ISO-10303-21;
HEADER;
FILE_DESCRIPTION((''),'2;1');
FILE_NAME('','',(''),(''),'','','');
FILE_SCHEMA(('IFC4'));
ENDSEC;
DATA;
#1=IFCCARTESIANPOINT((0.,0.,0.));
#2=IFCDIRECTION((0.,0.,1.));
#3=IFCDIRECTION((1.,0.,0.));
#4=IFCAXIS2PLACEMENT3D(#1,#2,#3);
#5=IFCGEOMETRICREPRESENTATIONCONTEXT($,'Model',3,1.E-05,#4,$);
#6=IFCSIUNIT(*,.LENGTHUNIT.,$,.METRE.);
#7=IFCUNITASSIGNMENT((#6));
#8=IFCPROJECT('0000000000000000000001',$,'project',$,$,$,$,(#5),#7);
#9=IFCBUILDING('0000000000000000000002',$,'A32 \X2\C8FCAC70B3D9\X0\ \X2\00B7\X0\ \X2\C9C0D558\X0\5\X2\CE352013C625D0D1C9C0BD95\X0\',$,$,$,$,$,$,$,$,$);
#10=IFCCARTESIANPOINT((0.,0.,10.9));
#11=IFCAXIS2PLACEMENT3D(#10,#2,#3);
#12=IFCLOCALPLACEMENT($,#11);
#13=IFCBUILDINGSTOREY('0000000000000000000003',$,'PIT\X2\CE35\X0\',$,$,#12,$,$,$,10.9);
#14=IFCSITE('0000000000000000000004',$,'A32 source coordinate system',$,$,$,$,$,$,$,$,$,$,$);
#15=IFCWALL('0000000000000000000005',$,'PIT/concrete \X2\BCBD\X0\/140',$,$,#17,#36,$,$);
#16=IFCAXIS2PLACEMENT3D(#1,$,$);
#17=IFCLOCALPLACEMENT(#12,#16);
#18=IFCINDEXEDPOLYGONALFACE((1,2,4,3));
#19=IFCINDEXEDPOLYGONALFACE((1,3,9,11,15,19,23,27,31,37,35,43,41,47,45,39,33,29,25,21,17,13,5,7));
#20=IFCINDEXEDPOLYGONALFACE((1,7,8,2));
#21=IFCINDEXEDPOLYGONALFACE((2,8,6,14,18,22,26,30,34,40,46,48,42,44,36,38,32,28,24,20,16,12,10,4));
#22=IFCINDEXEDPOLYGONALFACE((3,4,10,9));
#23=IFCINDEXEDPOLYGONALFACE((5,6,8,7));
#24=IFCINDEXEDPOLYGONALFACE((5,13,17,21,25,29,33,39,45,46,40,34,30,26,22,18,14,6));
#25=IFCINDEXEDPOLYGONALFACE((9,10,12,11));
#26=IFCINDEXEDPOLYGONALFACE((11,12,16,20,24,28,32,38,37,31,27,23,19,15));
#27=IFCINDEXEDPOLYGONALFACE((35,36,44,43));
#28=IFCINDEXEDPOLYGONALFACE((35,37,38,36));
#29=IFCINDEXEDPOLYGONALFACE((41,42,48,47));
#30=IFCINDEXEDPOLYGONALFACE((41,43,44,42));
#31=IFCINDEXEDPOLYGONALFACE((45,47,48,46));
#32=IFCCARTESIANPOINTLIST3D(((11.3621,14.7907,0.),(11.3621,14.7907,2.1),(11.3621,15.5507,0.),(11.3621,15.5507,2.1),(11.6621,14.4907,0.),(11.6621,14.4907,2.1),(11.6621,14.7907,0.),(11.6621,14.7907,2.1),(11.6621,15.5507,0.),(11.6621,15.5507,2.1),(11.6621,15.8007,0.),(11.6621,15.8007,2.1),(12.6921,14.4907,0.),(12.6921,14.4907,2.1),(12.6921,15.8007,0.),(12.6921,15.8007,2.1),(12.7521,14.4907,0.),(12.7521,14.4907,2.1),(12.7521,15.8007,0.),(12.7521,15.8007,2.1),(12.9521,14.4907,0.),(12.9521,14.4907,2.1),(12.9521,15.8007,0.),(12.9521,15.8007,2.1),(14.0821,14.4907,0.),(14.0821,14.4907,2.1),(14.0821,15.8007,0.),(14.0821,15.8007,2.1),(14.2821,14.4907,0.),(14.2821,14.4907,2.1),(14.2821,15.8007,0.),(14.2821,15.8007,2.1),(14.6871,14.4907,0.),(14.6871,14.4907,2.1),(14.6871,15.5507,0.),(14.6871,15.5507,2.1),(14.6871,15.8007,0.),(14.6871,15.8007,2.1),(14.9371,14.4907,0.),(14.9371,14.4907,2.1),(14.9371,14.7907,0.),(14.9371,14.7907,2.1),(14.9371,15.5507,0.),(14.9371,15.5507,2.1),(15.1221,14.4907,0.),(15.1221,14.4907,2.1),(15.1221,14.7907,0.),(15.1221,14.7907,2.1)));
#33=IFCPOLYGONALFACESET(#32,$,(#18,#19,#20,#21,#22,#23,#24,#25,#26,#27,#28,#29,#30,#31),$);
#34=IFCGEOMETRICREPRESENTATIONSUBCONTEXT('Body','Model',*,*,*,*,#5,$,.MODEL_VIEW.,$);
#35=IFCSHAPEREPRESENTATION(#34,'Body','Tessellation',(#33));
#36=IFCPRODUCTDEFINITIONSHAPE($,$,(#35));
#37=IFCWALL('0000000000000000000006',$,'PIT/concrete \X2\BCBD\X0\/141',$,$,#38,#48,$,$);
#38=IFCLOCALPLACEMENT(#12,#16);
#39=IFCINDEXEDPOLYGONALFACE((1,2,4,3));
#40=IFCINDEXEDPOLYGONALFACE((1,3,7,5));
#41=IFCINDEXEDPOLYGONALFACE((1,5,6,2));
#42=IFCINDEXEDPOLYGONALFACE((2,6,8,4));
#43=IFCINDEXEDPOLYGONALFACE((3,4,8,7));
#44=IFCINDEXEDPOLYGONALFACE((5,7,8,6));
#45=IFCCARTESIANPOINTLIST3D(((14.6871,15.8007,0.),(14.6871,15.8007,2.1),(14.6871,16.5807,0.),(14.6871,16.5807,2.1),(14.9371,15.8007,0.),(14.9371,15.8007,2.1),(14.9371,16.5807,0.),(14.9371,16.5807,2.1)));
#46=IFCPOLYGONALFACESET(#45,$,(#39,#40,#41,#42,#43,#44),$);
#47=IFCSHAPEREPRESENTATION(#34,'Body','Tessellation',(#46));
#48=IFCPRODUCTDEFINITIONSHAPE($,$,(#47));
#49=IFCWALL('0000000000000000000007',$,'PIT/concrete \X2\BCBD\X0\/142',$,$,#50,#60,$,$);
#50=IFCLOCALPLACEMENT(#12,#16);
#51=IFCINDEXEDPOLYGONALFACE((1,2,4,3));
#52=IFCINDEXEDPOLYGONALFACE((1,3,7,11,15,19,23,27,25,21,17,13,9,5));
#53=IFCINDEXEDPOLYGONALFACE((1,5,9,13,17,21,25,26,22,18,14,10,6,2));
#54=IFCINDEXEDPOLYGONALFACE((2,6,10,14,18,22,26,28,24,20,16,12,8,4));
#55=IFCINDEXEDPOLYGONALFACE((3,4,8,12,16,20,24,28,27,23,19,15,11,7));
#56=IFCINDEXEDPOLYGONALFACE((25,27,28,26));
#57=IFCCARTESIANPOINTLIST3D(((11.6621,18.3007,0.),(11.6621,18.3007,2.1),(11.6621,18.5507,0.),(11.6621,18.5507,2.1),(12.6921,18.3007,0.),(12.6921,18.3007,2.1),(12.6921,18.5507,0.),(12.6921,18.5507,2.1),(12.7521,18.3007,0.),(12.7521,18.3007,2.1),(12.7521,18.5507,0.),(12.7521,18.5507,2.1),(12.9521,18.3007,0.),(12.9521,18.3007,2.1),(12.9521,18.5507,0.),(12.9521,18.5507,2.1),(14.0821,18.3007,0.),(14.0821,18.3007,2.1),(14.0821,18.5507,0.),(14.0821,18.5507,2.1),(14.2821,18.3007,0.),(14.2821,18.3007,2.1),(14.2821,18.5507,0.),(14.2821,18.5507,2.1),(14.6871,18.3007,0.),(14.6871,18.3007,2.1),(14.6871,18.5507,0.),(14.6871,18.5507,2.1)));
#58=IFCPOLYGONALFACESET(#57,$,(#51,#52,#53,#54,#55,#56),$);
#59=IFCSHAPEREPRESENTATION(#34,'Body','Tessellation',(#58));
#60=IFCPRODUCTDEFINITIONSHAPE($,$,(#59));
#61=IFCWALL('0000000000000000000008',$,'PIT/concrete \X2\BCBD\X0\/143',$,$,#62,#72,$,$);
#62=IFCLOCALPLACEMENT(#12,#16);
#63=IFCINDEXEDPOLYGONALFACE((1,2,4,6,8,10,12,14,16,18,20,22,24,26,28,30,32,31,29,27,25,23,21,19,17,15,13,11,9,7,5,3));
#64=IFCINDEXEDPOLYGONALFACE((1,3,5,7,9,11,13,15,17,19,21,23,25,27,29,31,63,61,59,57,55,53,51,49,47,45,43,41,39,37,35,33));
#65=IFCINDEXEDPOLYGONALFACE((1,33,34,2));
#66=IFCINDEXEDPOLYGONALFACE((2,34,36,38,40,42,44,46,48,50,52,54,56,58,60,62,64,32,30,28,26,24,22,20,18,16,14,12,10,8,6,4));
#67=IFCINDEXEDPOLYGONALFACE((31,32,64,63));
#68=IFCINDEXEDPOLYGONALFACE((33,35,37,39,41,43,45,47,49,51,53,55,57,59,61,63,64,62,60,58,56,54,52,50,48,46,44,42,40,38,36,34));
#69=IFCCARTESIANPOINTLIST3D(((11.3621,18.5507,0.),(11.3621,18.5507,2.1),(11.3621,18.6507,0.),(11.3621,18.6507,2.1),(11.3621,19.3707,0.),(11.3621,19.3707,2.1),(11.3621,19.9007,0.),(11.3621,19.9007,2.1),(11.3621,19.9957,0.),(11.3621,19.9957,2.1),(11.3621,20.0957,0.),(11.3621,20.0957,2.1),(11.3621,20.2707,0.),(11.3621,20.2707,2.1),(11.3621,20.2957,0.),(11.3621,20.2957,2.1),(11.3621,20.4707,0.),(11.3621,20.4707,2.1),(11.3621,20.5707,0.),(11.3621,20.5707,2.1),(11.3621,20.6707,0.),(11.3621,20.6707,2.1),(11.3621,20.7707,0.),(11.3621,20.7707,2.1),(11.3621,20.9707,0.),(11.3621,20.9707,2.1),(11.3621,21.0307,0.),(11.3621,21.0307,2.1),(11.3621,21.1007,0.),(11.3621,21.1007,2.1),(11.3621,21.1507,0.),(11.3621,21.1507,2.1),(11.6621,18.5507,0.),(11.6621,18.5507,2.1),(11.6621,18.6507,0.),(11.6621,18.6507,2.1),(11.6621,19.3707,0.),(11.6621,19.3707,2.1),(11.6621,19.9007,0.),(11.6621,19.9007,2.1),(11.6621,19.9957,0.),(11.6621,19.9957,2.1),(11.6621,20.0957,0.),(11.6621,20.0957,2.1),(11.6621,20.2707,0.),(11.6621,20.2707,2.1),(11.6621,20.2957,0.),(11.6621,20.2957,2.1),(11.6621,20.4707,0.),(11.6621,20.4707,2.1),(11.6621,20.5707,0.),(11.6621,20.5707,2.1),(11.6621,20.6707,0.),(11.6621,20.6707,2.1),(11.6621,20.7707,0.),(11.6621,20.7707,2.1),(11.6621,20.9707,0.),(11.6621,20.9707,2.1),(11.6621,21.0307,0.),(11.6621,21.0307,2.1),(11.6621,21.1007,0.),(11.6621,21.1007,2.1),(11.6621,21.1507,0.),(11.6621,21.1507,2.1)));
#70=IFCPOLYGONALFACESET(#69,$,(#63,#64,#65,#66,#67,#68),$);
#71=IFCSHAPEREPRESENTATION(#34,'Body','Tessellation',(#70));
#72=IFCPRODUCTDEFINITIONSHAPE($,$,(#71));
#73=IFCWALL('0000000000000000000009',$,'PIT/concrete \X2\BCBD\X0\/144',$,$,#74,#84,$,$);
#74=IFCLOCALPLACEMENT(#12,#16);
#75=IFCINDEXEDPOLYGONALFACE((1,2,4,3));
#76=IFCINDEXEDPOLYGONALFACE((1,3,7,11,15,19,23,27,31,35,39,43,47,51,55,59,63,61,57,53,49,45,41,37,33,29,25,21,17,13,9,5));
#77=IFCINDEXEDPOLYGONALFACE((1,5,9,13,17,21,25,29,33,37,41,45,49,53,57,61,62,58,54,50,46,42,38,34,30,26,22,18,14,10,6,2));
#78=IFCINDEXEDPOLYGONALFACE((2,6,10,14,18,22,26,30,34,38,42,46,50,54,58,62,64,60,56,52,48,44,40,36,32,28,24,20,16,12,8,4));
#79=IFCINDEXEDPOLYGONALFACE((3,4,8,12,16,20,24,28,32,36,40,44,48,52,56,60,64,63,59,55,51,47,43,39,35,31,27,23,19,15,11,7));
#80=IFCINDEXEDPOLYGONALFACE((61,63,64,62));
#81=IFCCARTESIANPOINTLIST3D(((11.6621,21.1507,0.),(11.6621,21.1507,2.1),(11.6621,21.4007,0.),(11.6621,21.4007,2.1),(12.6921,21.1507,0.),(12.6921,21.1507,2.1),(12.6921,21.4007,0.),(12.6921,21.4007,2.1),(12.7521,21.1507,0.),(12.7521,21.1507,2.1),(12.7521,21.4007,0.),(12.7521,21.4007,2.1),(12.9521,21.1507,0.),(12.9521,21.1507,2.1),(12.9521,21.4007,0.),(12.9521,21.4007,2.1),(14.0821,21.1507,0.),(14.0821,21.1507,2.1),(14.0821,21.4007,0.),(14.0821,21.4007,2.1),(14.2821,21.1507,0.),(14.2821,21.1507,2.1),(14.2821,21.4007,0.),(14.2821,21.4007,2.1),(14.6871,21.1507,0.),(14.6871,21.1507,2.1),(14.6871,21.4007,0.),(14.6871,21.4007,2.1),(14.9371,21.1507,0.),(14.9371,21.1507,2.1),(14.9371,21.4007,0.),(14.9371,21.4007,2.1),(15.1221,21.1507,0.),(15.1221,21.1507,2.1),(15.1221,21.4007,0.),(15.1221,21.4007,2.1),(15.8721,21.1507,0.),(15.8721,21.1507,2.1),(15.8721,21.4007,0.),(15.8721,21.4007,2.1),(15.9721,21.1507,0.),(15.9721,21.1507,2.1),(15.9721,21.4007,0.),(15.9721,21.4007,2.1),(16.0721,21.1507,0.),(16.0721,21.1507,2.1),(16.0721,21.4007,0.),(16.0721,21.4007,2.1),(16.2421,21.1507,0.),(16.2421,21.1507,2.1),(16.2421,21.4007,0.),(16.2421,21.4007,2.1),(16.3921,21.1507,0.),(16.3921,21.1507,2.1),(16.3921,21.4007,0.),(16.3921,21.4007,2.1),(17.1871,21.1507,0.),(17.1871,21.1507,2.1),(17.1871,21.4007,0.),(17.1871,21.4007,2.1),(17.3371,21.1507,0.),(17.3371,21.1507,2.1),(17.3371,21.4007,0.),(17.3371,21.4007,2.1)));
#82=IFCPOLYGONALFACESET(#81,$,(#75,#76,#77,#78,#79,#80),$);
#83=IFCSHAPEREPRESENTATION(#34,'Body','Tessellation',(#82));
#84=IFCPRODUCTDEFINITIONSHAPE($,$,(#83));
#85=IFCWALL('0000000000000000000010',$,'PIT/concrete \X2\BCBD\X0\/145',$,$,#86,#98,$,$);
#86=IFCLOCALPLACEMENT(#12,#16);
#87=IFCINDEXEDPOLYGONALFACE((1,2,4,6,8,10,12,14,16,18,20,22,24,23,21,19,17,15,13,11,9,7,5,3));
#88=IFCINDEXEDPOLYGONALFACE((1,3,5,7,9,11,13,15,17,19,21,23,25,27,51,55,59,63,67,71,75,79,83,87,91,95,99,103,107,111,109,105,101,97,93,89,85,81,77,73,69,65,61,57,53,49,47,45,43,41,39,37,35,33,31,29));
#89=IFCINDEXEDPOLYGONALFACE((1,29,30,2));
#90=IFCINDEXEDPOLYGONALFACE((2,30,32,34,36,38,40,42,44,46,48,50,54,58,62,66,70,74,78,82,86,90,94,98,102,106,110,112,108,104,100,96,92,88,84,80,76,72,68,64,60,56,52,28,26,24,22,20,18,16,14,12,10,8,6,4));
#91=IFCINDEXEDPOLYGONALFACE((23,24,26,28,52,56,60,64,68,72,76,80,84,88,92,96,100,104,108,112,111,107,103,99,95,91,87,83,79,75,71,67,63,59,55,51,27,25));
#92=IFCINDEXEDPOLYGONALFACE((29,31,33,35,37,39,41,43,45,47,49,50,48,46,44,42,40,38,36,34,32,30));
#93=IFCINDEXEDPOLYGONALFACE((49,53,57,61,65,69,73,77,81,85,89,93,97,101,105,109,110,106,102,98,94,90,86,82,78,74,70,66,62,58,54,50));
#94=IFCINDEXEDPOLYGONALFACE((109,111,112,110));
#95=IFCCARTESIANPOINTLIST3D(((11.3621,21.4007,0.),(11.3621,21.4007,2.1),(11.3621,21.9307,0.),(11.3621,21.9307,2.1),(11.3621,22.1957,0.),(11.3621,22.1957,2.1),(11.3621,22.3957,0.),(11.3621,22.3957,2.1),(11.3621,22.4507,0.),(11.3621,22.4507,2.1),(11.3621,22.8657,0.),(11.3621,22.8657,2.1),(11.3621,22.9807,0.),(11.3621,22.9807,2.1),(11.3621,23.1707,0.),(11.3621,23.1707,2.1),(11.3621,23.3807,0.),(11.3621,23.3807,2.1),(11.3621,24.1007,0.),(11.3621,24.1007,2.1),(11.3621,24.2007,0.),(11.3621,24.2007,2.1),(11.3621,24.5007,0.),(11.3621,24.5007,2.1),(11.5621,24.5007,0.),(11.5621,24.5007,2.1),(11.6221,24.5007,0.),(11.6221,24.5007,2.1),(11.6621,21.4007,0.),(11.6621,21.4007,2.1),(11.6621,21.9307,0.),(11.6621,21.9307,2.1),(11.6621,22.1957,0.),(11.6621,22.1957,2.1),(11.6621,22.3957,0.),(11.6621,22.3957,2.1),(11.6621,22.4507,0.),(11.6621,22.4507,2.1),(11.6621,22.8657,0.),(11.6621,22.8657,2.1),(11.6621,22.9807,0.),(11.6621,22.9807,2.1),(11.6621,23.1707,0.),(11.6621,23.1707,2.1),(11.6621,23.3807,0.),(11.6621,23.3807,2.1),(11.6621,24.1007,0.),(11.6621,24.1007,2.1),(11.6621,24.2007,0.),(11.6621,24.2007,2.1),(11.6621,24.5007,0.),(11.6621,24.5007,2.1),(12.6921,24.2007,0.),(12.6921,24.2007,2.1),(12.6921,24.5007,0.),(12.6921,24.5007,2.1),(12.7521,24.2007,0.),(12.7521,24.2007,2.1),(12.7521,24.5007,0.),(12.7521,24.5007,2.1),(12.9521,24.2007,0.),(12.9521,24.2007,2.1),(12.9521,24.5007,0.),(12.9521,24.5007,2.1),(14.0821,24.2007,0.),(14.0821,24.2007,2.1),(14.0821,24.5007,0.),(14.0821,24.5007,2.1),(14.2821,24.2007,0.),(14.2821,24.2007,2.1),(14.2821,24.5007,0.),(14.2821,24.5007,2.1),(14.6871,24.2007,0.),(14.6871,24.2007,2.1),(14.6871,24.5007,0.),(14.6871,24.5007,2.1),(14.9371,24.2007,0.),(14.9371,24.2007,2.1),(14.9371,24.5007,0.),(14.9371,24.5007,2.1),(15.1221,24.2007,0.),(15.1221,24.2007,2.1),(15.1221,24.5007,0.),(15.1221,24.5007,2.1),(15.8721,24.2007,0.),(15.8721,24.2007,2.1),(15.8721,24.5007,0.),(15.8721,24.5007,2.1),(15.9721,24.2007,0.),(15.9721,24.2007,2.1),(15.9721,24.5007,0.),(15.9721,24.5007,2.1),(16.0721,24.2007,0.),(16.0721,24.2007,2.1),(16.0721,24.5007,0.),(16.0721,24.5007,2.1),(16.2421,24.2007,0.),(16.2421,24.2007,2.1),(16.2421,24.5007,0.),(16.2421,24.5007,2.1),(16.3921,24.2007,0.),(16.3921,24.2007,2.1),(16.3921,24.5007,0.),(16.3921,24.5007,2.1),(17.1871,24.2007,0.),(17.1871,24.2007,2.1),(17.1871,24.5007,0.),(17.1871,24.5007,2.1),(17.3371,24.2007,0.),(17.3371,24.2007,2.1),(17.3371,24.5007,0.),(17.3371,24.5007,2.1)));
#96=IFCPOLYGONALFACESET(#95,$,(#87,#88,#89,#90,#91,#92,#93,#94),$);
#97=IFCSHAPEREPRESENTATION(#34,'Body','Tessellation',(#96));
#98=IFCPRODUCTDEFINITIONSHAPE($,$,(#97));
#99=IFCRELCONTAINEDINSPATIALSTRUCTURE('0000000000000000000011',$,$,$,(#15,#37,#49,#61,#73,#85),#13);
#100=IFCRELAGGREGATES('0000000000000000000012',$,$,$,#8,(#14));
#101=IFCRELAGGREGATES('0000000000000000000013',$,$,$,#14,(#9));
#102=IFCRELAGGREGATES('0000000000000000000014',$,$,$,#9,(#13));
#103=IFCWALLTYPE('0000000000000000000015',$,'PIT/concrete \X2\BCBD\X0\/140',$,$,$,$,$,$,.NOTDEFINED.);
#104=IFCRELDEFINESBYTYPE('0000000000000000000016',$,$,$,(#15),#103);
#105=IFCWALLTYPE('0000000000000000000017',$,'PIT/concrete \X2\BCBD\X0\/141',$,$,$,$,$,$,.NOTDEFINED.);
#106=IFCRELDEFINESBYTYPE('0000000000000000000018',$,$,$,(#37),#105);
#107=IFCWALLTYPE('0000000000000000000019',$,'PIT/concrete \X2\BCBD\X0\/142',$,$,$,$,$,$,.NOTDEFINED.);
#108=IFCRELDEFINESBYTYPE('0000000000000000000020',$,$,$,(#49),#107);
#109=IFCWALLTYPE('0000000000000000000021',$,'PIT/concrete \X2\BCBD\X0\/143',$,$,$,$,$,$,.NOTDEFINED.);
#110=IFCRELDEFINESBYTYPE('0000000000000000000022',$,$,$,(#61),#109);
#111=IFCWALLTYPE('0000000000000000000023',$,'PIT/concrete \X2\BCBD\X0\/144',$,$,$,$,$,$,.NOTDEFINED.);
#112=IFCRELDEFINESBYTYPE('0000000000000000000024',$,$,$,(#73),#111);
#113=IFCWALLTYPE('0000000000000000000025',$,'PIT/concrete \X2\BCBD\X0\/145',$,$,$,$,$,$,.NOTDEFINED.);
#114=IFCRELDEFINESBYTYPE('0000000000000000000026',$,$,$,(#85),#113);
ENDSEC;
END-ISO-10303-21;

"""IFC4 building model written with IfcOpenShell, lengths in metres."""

from ifc_helpers import new_model, si_unit, frame, origin, origin_with_axes, place, context, subcontext, project, spatial, polyline, outline, extrude, source, transform, mapped, type_object, type_shapes, element, save


model = new_model("IFC4")

# Units and contexts
model_context = context("Model", 3, precision=1e-05, world=origin_with_axes())
body_context = subcontext(model_context, "Body", "Model", "MODEL_VIEW")
ifc_project = project(units=[si_unit("LENGTHUNIT", "METRE")], contexts=[model_context])

# Site, building, storey
site = spatial("IfcSite", under=ifc_project, Name="A32 source coordinate system")
building = spatial("IfcBuilding", under=site, Name="A32 주거동 · 지하5층–옥탑지붕")
storey_placement = place(None, frame((0.0, 0.0, 10.9), z_axis=(0.0, 0.0, 1.0), x_axis=(1.0, 0.0, 0.0)))
storey = spatial("IfcBuildingStorey", under=building, at=storey_placement, Name="PIT층", Elevation=10.9)

# Walls
wall_type_1 = type_object("IfcWallType", Name="PIT/concrete 벽/140", PredefinedType="NOTDEFINED")
shared_shape_1 = source(origin(), body_context, "Body", "SweptSolid", [
    extrude(outline(polyline([(12.9521, 15.8007), (14.0821, 15.8007), (14.2821, 15.8007), (14.6871, 15.8007), (14.6871, 15.5507), (14.9371, 15.5507), (14.9371, 14.7907), (15.1221, 14.7907), (15.1221, 14.4907), (14.9371, 14.4907), (14.6871, 14.4907), (14.2821, 14.4907), (14.0821, 14.4907), (12.9521, 14.4907), (12.7521, 14.4907), (12.6921, 14.4907), (11.6621, 14.4907), (11.6621, 14.7907), (11.3621, 14.7907), (11.3621, 15.5507), (11.6621, 15.5507), (11.6621, 15.8007), (12.6921, 15.8007), (12.7521, 15.8007), (12.9521, 15.8007)])), origin(), (0.0, 0.0, 1.0), 2.1),
])
type_shapes(wall_type_1, [shared_shape_1])
wall_1_placement = place(storey_placement, origin_with_axes())
element("IfcWall", 1, at=wall_1_placement, inside=storey, type_object=wall_type_1, Name="PIT/concrete 벽/140", context=body_context, shape_type="MappedRepresentation", body=[
    mapped(shared_shape_1, transform((0.0, 0.0, 0.0), scale=1.0)),
])
wall_type_2 = type_object("IfcWallType", Name="PIT/concrete 벽/141", PredefinedType="NOTDEFINED")
shared_shape_2 = source(origin(), body_context, "Body", "SweptSolid", [
    extrude(outline(polyline([(14.9371, 15.8007), (14.6871, 15.8007), (14.6871, 16.5807), (14.9371, 16.5807), (14.9371, 15.8007)])), origin(), (0.0, 0.0, 1.0), 2.1),
])
type_shapes(wall_type_2, [shared_shape_2])
wall_2_placement = place(storey_placement, origin_with_axes())
element("IfcWall", 2, at=wall_2_placement, inside=storey, type_object=wall_type_2, Name="PIT/concrete 벽/141", context=body_context, shape_type="MappedRepresentation", body=[
    mapped(shared_shape_2, transform((0.0, 0.0, 0.0), scale=1.0)),
])
wall_type_3 = type_object("IfcWallType", Name="PIT/concrete 벽/142", PredefinedType="NOTDEFINED")
shared_shape_3 = source(origin(), body_context, "Body", "SweptSolid", [
    extrude(outline(polyline([(12.7521, 18.5507), (12.9521, 18.5507), (14.0821, 18.5507), (14.2821, 18.5507), (14.6871, 18.5507), (14.6871, 18.3007), (14.2821, 18.3007), (14.0821, 18.3007), (12.9521, 18.3007), (12.7521, 18.3007), (12.6921, 18.3007), (11.6621, 18.3007), (11.6621, 18.5507), (12.6921, 18.5507), (12.7521, 18.5507)])), origin(), (0.0, 0.0, 1.0), 2.1),
])
type_shapes(wall_type_3, [shared_shape_3])
wall_3_placement = place(storey_placement, origin_with_axes())
element("IfcWall", 3, at=wall_3_placement, inside=storey, type_object=wall_type_3, Name="PIT/concrete 벽/142", context=body_context, shape_type="MappedRepresentation", body=[
    mapped(shared_shape_3, transform((0.0, 0.0, 0.0), scale=1.0)),
])
wall_type_4 = type_object("IfcWallType", Name="PIT/concrete 벽/143", PredefinedType="NOTDEFINED")
shared_shape_4 = source(origin(), body_context, "Body", "SweptSolid", [
    extrude(outline(polyline([(11.3621, 19.3707), (11.3621, 19.9007), (11.3621, 19.9957), (11.3621, 20.0957), (11.3621, 20.2707), (11.3621, 20.2957), (11.3621, 20.4707), (11.3621, 20.5707), (11.3621, 20.6707), (11.3621, 20.7707), (11.3621, 20.9707), (11.3621, 21.0307), (11.3621, 21.1007), (11.3621, 21.1507), (11.6621, 21.1507), (11.6621, 21.1007), (11.6621, 21.0307), (11.6621, 20.9707), (11.6621, 20.7707), (11.6621, 20.6707), (11.6621, 20.5707), (11.6621, 20.4707), (11.6621, 20.2957), (11.6621, 20.2707), (11.6621, 20.0957), (11.6621, 19.9957), (11.6621, 19.9007), (11.6621, 19.3707), (11.6621, 18.6507), (11.6621, 18.5507), (11.3621, 18.5507), (11.3621, 18.6507), (11.3621, 19.3707)])), origin(), (0.0, 0.0, 1.0), 2.1),
])
type_shapes(wall_type_4, [shared_shape_4])
wall_4_placement = place(storey_placement, origin_with_axes())
element("IfcWall", 4, at=wall_4_placement, inside=storey, type_object=wall_type_4, Name="PIT/concrete 벽/143", context=body_context, shape_type="MappedRepresentation", body=[
    mapped(shared_shape_4, transform((0.0, 0.0, 0.0), scale=1.0)),
])
wall_type_5 = type_object("IfcWallType", Name="PIT/concrete 벽/144", PredefinedType="NOTDEFINED")
shared_shape_5 = source(origin(), body_context, "Body", "SweptSolid", [
    extrude(outline(polyline([(12.7521, 21.4007), (12.9521, 21.4007), (14.0821, 21.4007), (14.2821, 21.4007), (14.6871, 21.4007), (14.9371, 21.4007), (15.1221, 21.4007), (15.8721, 21.4007), (15.9721, 21.4007), (16.0721, 21.4007), (16.2421, 21.4007), (16.3921, 21.4007), (17.1871, 21.4007), (17.3371, 21.4007), (17.3371, 21.1507), (17.1871, 21.1507), (16.3921, 21.1507), (16.2421, 21.1507), (16.0721, 21.1507), (15.9721, 21.1507), (15.8721, 21.1507), (15.1221, 21.1507), (14.9371, 21.1507), (14.6871, 21.1507), (14.2821, 21.1507), (14.0821, 21.1507), (12.9521, 21.1507), (12.7521, 21.1507), (12.6921, 21.1507), (11.6621, 21.1507), (11.6621, 21.4007), (12.6921, 21.4007), (12.7521, 21.4007)])), origin(), (0.0, 0.0, 1.0), 2.1),
])
type_shapes(wall_type_5, [shared_shape_5])
wall_5_placement = place(storey_placement, origin_with_axes())
element("IfcWall", 5, at=wall_5_placement, inside=storey, type_object=wall_type_5, Name="PIT/concrete 벽/144", context=body_context, shape_type="MappedRepresentation", body=[
    mapped(shared_shape_5, transform((0.0, 0.0, 0.0), scale=1.0)),
])
wall_type_6 = type_object("IfcWallType", Name="PIT/concrete 벽/145", PredefinedType="NOTDEFINED")
shared_shape_6 = source(origin(), body_context, "Body", "SweptSolid", [
    extrude(outline(polyline([(11.3621, 22.1957), (11.3621, 22.3957), (11.3621, 22.4507), (11.3621, 22.8657), (11.3621, 22.9807), (11.3621, 23.1707), (11.3621, 23.3807), (11.3621, 24.1007), (11.3621, 24.2007), (11.3621, 24.5007), (11.5621, 24.5007), (11.6221, 24.5007), (11.6621, 24.5007), (12.6921, 24.5007), (12.7521, 24.5007), (12.9521, 24.5007), (14.0821, 24.5007), (14.2821, 24.5007), (14.6871, 24.5007), (14.9371, 24.5007), (15.1221, 24.5007), (15.8721, 24.5007), (15.9721, 24.5007), (16.0721, 24.5007), (16.2421, 24.5007), (16.3921, 24.5007), (17.1871, 24.5007), (17.3371, 24.5007), (17.3371, 24.2007), (17.1871, 24.2007), (16.3921, 24.2007), (16.2421, 24.2007), (16.0721, 24.2007), (15.9721, 24.2007), (15.8721, 24.2007), (15.1221, 24.2007), (14.9371, 24.2007), (14.6871, 24.2007), (14.2821, 24.2007), (14.0821, 24.2007), (12.9521, 24.2007), (12.7521, 24.2007), (12.6921, 24.2007), (11.6621, 24.2007), (11.6621, 24.1007), (11.6621, 23.3807), (11.6621, 23.1707), (11.6621, 22.9807), (11.6621, 22.8657), (11.6621, 22.4507), (11.6621, 22.3957), (11.6621, 22.1957), (11.6621, 21.9307), (11.6621, 21.4007), (11.3621, 21.4007), (11.3621, 21.9307), (11.3621, 22.1957)])), origin(), (0.0, 0.0, 1.0), 2.1),
])
type_shapes(wall_type_6, [shared_shape_6])
wall_6_placement = place(storey_placement, origin_with_axes())
element("IfcWall", 6, at=wall_6_placement, inside=storey, type_object=wall_type_6, Name="PIT/concrete 벽/145", context=body_context, shape_type="MappedRepresentation", body=[
    mapped(shared_shape_6, transform((0.0, 0.0, 0.0), scale=1.0)),
])

save(model, "model.ifc")
